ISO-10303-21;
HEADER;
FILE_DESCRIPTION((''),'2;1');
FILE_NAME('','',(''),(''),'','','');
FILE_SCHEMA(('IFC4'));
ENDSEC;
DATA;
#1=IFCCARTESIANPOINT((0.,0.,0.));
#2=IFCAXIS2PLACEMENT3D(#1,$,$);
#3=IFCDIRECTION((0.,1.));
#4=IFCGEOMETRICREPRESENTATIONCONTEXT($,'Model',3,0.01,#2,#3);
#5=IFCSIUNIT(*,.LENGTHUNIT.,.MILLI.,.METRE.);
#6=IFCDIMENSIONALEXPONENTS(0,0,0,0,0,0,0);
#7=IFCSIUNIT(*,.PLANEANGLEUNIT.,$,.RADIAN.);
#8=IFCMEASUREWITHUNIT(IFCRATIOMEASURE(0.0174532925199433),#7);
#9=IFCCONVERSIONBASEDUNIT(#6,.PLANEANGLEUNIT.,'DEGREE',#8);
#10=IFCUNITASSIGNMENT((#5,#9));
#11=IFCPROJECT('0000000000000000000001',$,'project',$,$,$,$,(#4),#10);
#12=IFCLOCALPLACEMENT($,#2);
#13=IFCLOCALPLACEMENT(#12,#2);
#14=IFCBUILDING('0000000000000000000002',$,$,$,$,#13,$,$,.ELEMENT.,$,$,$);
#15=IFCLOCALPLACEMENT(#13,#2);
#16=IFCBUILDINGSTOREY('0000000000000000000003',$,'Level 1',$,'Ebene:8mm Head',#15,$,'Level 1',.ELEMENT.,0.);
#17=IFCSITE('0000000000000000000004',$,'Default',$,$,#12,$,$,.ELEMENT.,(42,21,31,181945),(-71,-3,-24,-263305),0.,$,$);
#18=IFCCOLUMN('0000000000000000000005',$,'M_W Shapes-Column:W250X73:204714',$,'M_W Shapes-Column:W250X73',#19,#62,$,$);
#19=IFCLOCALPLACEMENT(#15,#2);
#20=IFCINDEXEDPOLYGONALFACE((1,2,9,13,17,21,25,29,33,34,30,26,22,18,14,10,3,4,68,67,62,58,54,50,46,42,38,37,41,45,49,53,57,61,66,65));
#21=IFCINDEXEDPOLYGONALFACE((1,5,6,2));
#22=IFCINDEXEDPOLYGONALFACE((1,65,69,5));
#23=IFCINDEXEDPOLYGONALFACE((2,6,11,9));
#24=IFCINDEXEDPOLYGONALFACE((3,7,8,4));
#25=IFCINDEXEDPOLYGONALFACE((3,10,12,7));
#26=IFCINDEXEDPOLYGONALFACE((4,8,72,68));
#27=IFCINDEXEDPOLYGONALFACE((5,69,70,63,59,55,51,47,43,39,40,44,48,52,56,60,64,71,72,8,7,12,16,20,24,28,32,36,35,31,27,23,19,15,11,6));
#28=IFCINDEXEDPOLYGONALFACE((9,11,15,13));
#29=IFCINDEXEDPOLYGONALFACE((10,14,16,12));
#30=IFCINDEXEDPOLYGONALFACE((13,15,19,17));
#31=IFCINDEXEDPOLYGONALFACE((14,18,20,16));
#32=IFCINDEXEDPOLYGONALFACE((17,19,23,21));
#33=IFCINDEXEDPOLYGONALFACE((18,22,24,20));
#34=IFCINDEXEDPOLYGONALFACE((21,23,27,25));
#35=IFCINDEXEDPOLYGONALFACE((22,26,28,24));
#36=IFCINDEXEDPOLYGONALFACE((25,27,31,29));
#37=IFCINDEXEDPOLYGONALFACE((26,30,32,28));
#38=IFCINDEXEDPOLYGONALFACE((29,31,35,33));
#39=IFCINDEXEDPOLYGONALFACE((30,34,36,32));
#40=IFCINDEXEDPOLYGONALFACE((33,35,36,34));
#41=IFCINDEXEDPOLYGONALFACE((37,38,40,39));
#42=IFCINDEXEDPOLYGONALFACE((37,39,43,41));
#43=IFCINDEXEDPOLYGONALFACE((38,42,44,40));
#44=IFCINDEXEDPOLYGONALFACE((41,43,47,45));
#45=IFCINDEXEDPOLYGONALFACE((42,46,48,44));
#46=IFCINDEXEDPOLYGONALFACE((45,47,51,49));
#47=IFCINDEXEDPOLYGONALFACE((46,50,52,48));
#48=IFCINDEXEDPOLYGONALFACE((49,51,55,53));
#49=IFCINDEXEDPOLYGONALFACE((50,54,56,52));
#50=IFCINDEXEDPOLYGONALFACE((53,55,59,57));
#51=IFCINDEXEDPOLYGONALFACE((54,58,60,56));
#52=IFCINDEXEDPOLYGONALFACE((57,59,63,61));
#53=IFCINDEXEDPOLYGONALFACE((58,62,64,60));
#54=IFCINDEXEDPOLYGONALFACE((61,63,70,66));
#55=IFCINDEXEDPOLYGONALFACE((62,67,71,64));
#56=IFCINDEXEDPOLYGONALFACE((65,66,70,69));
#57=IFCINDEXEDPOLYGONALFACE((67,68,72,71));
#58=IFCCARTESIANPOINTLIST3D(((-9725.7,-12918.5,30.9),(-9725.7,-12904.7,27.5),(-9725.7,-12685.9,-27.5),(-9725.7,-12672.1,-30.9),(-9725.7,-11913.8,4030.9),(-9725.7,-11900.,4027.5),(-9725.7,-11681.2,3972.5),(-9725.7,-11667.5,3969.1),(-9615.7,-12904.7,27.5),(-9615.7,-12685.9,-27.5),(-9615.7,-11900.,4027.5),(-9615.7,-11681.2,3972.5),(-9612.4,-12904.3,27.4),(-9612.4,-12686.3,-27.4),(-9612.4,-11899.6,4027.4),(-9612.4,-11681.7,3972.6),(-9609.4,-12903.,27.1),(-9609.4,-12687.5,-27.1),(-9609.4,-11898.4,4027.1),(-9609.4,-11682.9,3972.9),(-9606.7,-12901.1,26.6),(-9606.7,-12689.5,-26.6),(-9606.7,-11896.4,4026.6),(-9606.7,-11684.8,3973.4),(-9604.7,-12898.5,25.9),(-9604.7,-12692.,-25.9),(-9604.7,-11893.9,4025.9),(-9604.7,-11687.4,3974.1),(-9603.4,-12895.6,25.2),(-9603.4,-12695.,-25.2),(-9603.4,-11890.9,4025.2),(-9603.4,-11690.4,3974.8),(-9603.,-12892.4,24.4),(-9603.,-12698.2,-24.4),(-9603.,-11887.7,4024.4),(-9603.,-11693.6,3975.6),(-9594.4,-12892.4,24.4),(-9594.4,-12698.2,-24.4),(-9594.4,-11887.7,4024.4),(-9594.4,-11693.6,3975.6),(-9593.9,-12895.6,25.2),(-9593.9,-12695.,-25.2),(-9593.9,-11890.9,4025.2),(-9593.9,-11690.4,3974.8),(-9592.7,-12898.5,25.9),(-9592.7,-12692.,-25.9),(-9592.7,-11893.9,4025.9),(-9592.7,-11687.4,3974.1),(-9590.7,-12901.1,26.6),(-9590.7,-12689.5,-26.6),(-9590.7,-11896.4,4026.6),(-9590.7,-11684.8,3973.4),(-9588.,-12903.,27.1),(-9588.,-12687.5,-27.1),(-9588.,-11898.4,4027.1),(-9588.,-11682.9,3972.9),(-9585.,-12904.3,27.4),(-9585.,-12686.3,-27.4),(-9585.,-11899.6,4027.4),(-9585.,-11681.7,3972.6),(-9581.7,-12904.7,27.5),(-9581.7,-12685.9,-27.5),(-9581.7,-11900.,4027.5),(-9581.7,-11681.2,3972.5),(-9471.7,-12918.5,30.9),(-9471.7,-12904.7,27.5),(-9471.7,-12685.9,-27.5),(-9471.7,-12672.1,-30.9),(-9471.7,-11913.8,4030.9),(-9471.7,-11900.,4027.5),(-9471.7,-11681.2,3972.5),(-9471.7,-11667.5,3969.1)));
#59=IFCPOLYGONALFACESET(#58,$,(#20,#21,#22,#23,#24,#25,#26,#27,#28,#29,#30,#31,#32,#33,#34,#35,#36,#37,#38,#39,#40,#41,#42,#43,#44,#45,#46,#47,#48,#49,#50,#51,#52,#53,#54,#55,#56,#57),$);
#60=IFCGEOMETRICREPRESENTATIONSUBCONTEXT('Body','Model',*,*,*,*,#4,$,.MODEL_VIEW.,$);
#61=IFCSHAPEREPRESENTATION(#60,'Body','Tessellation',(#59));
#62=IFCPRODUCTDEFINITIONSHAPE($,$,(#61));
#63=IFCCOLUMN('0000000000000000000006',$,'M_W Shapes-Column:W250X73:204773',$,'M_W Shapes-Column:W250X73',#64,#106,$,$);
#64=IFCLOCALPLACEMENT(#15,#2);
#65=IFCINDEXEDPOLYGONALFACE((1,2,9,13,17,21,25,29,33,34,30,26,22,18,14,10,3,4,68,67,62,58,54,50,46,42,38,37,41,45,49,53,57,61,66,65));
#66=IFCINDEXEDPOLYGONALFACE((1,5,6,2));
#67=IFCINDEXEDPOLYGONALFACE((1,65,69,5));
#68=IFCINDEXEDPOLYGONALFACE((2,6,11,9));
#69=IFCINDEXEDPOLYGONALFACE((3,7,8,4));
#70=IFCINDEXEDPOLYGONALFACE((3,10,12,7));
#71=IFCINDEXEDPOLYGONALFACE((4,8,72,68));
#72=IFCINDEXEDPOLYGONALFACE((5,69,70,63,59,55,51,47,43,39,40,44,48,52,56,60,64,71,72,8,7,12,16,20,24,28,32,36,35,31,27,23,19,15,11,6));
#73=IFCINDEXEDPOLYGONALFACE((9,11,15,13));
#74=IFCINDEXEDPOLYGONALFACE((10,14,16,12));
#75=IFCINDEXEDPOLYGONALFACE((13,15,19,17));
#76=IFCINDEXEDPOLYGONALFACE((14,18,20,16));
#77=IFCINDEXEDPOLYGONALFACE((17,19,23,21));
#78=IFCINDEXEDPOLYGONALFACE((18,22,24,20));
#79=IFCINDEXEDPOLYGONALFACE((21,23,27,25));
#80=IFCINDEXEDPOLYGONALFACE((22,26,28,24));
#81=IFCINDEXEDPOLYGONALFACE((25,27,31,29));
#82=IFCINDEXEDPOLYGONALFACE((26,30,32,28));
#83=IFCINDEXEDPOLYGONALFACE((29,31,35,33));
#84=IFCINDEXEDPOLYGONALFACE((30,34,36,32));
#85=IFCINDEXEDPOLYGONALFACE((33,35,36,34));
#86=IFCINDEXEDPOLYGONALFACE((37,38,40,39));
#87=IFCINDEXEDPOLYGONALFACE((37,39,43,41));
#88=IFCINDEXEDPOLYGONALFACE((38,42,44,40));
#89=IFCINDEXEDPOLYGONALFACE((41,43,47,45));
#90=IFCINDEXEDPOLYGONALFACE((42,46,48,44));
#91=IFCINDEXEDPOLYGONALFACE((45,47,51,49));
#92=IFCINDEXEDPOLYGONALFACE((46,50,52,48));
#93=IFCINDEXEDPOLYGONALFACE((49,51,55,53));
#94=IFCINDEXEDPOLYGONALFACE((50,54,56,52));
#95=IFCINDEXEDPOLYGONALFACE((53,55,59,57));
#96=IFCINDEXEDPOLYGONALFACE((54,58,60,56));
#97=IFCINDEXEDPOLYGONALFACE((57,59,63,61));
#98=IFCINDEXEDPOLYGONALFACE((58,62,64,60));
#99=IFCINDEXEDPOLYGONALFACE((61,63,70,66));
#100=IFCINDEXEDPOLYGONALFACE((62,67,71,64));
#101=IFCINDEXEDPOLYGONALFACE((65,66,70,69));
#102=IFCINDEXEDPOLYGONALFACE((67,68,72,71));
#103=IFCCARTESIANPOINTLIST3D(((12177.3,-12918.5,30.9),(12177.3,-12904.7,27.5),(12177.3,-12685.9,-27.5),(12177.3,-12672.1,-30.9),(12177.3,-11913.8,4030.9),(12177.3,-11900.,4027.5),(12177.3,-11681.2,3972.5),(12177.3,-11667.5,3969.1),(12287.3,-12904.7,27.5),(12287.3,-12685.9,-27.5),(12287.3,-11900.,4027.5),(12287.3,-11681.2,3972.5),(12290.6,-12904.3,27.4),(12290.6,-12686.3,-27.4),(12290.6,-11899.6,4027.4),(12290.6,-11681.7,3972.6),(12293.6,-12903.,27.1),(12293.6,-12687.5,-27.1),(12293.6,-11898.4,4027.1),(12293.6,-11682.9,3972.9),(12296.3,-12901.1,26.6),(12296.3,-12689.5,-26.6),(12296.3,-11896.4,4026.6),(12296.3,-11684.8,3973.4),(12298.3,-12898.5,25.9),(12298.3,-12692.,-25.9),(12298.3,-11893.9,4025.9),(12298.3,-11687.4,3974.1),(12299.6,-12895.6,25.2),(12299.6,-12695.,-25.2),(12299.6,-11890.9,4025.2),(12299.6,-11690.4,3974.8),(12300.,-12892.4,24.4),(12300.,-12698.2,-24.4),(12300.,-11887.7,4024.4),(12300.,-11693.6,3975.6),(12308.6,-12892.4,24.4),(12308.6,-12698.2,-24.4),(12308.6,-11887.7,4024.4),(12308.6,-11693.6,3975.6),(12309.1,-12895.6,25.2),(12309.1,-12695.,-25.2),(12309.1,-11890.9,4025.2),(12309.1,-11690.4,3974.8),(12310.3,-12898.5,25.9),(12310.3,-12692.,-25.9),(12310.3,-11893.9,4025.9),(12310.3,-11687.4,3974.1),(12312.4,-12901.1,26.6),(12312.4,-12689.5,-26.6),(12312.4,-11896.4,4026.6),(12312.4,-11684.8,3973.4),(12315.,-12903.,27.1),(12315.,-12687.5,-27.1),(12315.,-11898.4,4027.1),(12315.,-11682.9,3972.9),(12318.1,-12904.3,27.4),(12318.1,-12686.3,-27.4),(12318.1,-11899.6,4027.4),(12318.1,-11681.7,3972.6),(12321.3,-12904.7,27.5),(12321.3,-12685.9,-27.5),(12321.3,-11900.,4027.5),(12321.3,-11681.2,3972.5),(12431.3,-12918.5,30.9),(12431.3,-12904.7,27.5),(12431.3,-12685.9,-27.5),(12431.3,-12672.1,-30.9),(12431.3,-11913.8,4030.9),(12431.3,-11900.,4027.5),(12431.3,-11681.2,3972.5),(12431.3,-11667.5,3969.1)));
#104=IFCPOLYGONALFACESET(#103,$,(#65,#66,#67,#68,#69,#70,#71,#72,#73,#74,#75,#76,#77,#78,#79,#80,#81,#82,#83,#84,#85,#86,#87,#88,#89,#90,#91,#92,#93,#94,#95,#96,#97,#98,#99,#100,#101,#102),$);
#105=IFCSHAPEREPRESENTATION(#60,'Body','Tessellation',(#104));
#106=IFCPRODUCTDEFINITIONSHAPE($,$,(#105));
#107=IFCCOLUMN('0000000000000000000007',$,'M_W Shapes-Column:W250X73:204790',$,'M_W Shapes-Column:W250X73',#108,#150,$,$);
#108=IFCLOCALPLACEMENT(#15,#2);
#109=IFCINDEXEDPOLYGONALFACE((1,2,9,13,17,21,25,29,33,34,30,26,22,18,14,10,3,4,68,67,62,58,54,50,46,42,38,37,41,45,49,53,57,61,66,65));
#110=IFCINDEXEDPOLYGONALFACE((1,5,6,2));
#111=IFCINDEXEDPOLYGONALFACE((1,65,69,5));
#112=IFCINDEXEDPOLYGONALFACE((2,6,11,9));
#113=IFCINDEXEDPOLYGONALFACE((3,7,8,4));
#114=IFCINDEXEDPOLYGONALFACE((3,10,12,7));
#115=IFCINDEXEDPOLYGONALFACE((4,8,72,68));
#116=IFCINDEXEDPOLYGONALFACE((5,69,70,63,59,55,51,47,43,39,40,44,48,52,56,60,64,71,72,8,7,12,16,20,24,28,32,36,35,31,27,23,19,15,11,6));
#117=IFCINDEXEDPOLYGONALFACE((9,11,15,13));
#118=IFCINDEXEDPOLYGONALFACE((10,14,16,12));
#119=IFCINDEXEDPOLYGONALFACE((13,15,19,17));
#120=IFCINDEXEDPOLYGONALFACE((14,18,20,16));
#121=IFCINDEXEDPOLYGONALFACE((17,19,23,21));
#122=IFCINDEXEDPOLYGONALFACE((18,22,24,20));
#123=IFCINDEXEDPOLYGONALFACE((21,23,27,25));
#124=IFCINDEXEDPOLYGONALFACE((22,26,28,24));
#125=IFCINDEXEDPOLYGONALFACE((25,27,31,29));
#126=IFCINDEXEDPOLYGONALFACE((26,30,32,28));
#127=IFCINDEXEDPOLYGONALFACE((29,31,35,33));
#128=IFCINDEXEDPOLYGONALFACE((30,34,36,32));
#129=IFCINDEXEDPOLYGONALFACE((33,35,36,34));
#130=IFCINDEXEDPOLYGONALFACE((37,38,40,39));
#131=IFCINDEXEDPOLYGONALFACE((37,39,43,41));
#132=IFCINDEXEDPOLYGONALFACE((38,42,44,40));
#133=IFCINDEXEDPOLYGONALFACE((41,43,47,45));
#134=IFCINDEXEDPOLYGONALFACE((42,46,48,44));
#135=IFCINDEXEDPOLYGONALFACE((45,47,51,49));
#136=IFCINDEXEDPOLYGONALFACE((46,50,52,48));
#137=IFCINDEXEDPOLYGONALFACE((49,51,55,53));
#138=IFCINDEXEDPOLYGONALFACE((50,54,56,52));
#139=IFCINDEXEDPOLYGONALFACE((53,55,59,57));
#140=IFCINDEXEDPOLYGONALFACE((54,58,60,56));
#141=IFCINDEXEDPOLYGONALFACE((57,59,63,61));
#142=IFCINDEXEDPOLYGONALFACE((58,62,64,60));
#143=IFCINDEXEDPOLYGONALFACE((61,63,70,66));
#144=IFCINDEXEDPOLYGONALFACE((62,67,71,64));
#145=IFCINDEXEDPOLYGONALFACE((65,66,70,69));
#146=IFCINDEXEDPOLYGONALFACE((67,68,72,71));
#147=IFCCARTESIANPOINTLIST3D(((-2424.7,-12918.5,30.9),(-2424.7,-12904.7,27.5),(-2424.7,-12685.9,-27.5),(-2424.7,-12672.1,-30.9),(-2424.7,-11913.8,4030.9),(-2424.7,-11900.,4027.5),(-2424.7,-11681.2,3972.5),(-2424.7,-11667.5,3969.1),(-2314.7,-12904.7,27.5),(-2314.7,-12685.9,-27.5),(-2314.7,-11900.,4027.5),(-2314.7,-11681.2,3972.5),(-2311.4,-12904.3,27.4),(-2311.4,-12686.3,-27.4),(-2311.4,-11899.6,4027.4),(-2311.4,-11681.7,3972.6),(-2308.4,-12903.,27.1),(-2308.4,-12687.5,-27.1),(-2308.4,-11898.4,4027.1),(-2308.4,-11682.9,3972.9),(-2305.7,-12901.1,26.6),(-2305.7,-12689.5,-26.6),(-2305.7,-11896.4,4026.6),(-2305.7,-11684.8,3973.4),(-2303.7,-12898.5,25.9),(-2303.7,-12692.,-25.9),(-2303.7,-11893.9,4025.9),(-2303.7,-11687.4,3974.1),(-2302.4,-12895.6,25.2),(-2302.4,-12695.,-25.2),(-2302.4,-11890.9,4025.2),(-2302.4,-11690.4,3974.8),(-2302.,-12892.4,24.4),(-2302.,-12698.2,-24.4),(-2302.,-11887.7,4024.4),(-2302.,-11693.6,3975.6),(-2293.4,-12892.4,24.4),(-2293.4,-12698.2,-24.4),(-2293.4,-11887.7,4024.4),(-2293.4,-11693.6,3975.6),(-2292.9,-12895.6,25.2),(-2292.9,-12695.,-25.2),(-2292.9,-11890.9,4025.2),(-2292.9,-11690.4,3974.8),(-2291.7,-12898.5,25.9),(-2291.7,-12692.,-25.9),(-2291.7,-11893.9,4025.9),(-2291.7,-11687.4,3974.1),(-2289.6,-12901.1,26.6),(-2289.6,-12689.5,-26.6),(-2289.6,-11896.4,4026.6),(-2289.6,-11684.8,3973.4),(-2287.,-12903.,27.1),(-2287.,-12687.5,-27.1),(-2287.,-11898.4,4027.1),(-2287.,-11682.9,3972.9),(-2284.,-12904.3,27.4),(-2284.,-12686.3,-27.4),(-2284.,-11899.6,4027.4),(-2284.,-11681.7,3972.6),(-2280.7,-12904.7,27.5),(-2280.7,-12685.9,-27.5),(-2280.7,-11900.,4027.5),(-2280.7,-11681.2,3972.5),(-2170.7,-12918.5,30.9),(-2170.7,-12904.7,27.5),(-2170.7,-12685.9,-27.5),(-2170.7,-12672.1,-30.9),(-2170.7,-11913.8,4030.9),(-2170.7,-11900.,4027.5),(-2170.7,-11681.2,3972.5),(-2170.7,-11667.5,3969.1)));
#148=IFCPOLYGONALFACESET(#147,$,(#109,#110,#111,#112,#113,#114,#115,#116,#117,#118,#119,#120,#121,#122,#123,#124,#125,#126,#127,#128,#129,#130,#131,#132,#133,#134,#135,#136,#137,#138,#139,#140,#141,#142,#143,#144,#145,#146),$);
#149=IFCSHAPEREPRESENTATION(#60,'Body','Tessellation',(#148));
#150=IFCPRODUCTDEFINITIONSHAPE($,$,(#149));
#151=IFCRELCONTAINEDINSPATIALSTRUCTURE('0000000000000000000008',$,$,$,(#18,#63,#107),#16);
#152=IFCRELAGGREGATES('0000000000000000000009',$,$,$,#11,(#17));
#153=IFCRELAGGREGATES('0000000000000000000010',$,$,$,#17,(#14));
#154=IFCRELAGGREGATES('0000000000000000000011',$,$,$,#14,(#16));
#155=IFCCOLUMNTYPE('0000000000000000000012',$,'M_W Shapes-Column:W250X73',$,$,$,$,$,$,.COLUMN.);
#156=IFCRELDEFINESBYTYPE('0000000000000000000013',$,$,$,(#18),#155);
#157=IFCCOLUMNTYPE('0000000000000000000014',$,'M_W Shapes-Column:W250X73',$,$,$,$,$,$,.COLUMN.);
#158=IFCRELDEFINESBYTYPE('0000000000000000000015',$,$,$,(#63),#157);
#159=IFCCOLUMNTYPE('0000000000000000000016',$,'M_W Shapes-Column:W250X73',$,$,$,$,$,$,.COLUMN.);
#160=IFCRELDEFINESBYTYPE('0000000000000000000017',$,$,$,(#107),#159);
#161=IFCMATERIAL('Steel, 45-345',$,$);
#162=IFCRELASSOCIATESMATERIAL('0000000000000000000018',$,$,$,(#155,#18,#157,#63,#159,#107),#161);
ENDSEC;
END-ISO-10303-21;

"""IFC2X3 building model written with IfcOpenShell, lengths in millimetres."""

from ifc_helpers import new_model, entity, si_unit, converted_unit, direction, frame, frame_2d, origin, place, context, subcontext, project, spatial, polyline, circle_curve, parameter, trimmed, segment, composite_curve, outline, extrude, source, transform, mapped, material, type_object, type_shapes, element, save


model = new_model("IFC2X3")

# Units and contexts
model_context = context("Model", 3, precision=0.01, world=origin(), true_north=direction((0.0, 1.0)))
body_context = subcontext(model_context, "Body", "Model", "MODEL_VIEW")
ifc_project = project(units=[si_unit("LENGTHUNIT", "METRE", prefix="MILLI"), converted_unit("PLANEANGLEUNIT", "DEGREE", entity("IfcRatioMeasure", 0.0174532925199433), si_unit("PLANEANGLEUNIT", "RADIAN"), dimensions=[0, 0, 0, 0, 0, 0, 0])], contexts=[model_context])

# Site, building, storey
site_placement = place(None, origin())
site = spatial("IfcSite", under=ifc_project, at=site_placement, Name="Default", CompositionType="ELEMENT", RefLatitude=(42, 21, 31, 181945), RefLongitude=(-71, -3, -24, -263305), RefElevation=0.0)
building_placement = place(site_placement, origin())
building = spatial("IfcBuilding", under=site, at=building_placement, CompositionType="ELEMENT")
storey_placement = place(building_placement, origin())
storey = spatial("IfcBuildingStorey", under=building, at=storey_placement, Name="Level 1", ObjectType="Ebene:8mm Head", LongName="Level 1", CompositionType="ELEMENT", Elevation=0.0)

# Columns
ifc_material_1 = material(Name="Steel, 45-345")
column_type_1 = type_object("IfcColumnType", Name="M_W Shapes-Column:W250X73", PredefinedType="COLUMN", material=ifc_material_1)
shared_shape_1 = source(origin(), body_context, "Body", "SweptSolid", [
    extrude(outline(composite_curve([segment(polyline([(112.8, -127.0), (127.0, -127.0)]), True, "CONTINUOUS"), segment(polyline([(127.0, -127.0), (127.0, 127.0)]), True, "CONTINUOUS"), segment(polyline([(127.0, 127.0), (112.8, 127.0)]), True, "CONTINUOUS"), segment(polyline([(112.8, 127.0), (112.8, 17.0)]), True, "CONTINUOUS"), segment(trimmed(circle_curve(frame_2d((100.1, 17.0), x_axis=(1.0, 0.0)), 12.7), [parameter(270.0)], [parameter(0.0)], True, "PARAMETER"), False, "CONTINUOUS"), segment(polyline([(100.1, 4.3), (-100.1, 4.3)]), True, "CONTINUOUS"), segment(trimmed(circle_curve(frame_2d((-100.1, 17.0), x_axis=(0.0, -1.0)), 12.7), [parameter(270.0)], [parameter(0.0)], True, "PARAMETER"), False, "CONTINUOUS"), segment(polyline([(-112.8, 17.0), (-112.8, 127.0)]), True, "CONTINUOUS"), segment(polyline([(-112.8, 127.0), (-127.0, 127.0)]), True, "CONTINUOUS"), segment(polyline([(-127.0, 127.0), (-127.0, -127.0)]), True, "CONTINUOUS"), segment(polyline([(-127.0, -127.0), (-112.8, -127.0)]), True, "CONTINUOUS"), segment(polyline([(-112.8, -127.0), (-112.8, -17.0)]), True, "CONTINUOUS"), segment(trimmed(circle_curve(frame_2d((-100.1, -17.0), x_axis=(-1.0, 0.0)), 12.7), [parameter(270.0)], [parameter(0.0)], True, "PARAMETER"), False, "CONTINUOUS"), segment(polyline([(-100.1, -4.3), (100.1, -4.3)]), True, "CONTINUOUS"), segment(trimmed(circle_curve(frame_2d((100.1, -17.0), x_axis=(0.0, 1.0)), 12.7), [parameter(270.0)], [parameter(0.0)], True, "PARAMETER"), False, "CONTINUOUS"), segment(polyline([(112.8, -17.0), (112.8, -127.0)]), True, "CONTINUOUS")], self_intersect=False)), frame((-9598.7, -12795.3, 0.0), z_axis=(0.0, 0.243596, 0.969877), x_axis=(0.0, -0.969877, 0.243596)), (0.0, 0.0, 1.0), 4124.2),
])
type_shapes(column_type_1, [shared_shape_1])
column_1_placement = place(storey_placement, origin())
element("IfcColumn", 1, at=column_1_placement, inside=storey, type_object=column_type_1, material=ifc_material_1, Name="M_W Shapes-Column:W250X73:204714", ObjectType="M_W Shapes-Column:W250X73", context=body_context, shape_type="MappedRepresentation", body=[
    mapped(shared_shape_1, transform((0.0, 0.0, 0.0), scale=1.0)),
])
column_type_2 = type_object("IfcColumnType", Name="M_W Shapes-Column:W250X73", PredefinedType="COLUMN", material=ifc_material_1)
shared_shape_2 = source(origin(), body_context, "Body", "SweptSolid", [
    extrude(outline(composite_curve([segment(polyline([(112.8, -127.0), (127.0, -127.0)]), True, "CONTINUOUS"), segment(polyline([(127.0, -127.0), (127.0, 127.0)]), True, "CONTINUOUS"), segment(polyline([(127.0, 127.0), (112.8, 127.0)]), True, "CONTINUOUS"), segment(polyline([(112.8, 127.0), (112.8, 17.0)]), True, "CONTINUOUS"), segment(trimmed(circle_curve(frame_2d((100.1, 17.0), x_axis=(1.0, 0.0)), 12.7), [parameter(270.0)], [parameter(0.0)], True, "PARAMETER"), False, "CONTINUOUS"), segment(polyline([(100.1, 4.3), (-100.1, 4.3)]), True, "CONTINUOUS"), segment(trimmed(circle_curve(frame_2d((-100.1, 17.0), x_axis=(0.0, -1.0)), 12.7), [parameter(270.0)], [parameter(0.0)], True, "PARAMETER"), False, "CONTINUOUS"), segment(polyline([(-112.8, 17.0), (-112.8, 127.0)]), True, "CONTINUOUS"), segment(polyline([(-112.8, 127.0), (-127.0, 127.0)]), True, "CONTINUOUS"), segment(polyline([(-127.0, 127.0), (-127.0, -127.0)]), True, "CONTINUOUS"), segment(polyline([(-127.0, -127.0), (-112.8, -127.0)]), True, "CONTINUOUS"), segment(polyline([(-112.8, -127.0), (-112.8, -17.0)]), True, "CONTINUOUS"), segment(trimmed(circle_curve(frame_2d((-100.1, -17.0), x_axis=(-1.0, 0.0)), 12.7), [parameter(270.0)], [parameter(0.0)], True, "PARAMETER"), False, "CONTINUOUS"), segment(polyline([(-100.1, -4.3), (100.1, -4.3)]), True, "CONTINUOUS"), segment(trimmed(circle_curve(frame_2d((100.1, -17.0), x_axis=(0.0, 1.0)), 12.7), [parameter(270.0)], [parameter(0.0)], True, "PARAMETER"), False, "CONTINUOUS"), segment(polyline([(112.8, -17.0), (112.8, -127.0)]), True, "CONTINUOUS")], self_intersect=False)), frame((12304.3, -12795.3, 0.0), z_axis=(0.0, 0.243596, 0.969877), x_axis=(0.0, -0.969877, 0.243596)), (0.0, 0.0, 1.0), 4124.2),
])
type_shapes(column_type_2, [shared_shape_2])
column_2_placement = place(storey_placement, origin())
element("IfcColumn", 2, at=column_2_placement, inside=storey, type_object=column_type_2, material=ifc_material_1, Name="M_W Shapes-Column:W250X73:204773", ObjectType="M_W Shapes-Column:W250X73", context=body_context, shape_type="MappedRepresentation", body=[
    mapped(shared_shape_2, transform((0.0, 0.0, 0.0), scale=1.0)),
])
column_type_3 = type_object("IfcColumnType", Name="M_W Shapes-Column:W250X73", PredefinedType="COLUMN", material=ifc_material_1)
shared_shape_3 = source(origin(), body_context, "Body", "SweptSolid", [
    extrude(outline(composite_curve([segment(polyline([(112.8, -127.0), (127.0, -127.0)]), True, "CONTINUOUS"), segment(polyline([(127.0, -127.0), (127.0, 127.0)]), True, "CONTINUOUS"), segment(polyline([(127.0, 127.0), (112.8, 127.0)]), True, "CONTINUOUS"), segment(polyline([(112.8, 127.0), (112.8, 17.0)]), True, "CONTINUOUS"), segment(trimmed(circle_curve(frame_2d((100.1, 17.0), x_axis=(1.0, 0.0)), 12.7), [parameter(270.0)], [parameter(0.0)], True, "PARAMETER"), False, "CONTINUOUS"), segment(polyline([(100.1, 4.3), (-100.1, 4.3)]), True, "CONTINUOUS"), segment(trimmed(circle_curve(frame_2d((-100.1, 17.0), x_axis=(0.0, -1.0)), 12.7), [parameter(270.0)], [parameter(0.0)], True, "PARAMETER"), False, "CONTINUOUS"), segment(polyline([(-112.8, 17.0), (-112.8, 127.0)]), True, "CONTINUOUS"), segment(polyline([(-112.8, 127.0), (-127.0, 127.0)]), True, "CONTINUOUS"), segment(polyline([(-127.0, 127.0), (-127.0, -127.0)]), True, "CONTINUOUS"), segment(polyline([(-127.0, -127.0), (-112.8, -127.0)]), True, "CONTINUOUS"), segment(polyline([(-112.8, -127.0), (-112.8, -17.0)]), True, "CONTINUOUS"), segment(trimmed(circle_curve(frame_2d((-100.1, -17.0), x_axis=(-1.0, 0.0)), 12.7), [parameter(270.0)], [parameter(0.0)], True, "PARAMETER"), False, "CONTINUOUS"), segment(polyline([(-100.1, -4.3), (100.1, -4.3)]), True, "CONTINUOUS"), segment(trimmed(circle_curve(frame_2d((100.1, -17.0), x_axis=(0.0, 1.0)), 12.7), [parameter(270.0)], [parameter(0.0)], True, "PARAMETER"), False, "CONTINUOUS"), segment(polyline([(112.8, -17.0), (112.8, -127.0)]), True, "CONTINUOUS")], self_intersect=False)), frame((-2297.7, -12795.3, 0.0), z_axis=(0.0, 0.243596, 0.969877), x_axis=(0.0, -0.969877, 0.243596)), (0.0, 0.0, 1.0), 4124.2),
])
type_shapes(column_type_3, [shared_shape_3])
column_3_placement = place(storey_placement, origin())
element("IfcColumn", 3, at=column_3_placement, inside=storey, type_object=column_type_3, material=ifc_material_1, Name="M_W Shapes-Column:W250X73:204790", ObjectType="M_W Shapes-Column:W250X73", context=body_context, shape_type="MappedRepresentation", body=[
    mapped(shared_shape_3, transform((0.0, 0.0, 0.0), scale=1.0)),
])

save(model, "model.ifc")
